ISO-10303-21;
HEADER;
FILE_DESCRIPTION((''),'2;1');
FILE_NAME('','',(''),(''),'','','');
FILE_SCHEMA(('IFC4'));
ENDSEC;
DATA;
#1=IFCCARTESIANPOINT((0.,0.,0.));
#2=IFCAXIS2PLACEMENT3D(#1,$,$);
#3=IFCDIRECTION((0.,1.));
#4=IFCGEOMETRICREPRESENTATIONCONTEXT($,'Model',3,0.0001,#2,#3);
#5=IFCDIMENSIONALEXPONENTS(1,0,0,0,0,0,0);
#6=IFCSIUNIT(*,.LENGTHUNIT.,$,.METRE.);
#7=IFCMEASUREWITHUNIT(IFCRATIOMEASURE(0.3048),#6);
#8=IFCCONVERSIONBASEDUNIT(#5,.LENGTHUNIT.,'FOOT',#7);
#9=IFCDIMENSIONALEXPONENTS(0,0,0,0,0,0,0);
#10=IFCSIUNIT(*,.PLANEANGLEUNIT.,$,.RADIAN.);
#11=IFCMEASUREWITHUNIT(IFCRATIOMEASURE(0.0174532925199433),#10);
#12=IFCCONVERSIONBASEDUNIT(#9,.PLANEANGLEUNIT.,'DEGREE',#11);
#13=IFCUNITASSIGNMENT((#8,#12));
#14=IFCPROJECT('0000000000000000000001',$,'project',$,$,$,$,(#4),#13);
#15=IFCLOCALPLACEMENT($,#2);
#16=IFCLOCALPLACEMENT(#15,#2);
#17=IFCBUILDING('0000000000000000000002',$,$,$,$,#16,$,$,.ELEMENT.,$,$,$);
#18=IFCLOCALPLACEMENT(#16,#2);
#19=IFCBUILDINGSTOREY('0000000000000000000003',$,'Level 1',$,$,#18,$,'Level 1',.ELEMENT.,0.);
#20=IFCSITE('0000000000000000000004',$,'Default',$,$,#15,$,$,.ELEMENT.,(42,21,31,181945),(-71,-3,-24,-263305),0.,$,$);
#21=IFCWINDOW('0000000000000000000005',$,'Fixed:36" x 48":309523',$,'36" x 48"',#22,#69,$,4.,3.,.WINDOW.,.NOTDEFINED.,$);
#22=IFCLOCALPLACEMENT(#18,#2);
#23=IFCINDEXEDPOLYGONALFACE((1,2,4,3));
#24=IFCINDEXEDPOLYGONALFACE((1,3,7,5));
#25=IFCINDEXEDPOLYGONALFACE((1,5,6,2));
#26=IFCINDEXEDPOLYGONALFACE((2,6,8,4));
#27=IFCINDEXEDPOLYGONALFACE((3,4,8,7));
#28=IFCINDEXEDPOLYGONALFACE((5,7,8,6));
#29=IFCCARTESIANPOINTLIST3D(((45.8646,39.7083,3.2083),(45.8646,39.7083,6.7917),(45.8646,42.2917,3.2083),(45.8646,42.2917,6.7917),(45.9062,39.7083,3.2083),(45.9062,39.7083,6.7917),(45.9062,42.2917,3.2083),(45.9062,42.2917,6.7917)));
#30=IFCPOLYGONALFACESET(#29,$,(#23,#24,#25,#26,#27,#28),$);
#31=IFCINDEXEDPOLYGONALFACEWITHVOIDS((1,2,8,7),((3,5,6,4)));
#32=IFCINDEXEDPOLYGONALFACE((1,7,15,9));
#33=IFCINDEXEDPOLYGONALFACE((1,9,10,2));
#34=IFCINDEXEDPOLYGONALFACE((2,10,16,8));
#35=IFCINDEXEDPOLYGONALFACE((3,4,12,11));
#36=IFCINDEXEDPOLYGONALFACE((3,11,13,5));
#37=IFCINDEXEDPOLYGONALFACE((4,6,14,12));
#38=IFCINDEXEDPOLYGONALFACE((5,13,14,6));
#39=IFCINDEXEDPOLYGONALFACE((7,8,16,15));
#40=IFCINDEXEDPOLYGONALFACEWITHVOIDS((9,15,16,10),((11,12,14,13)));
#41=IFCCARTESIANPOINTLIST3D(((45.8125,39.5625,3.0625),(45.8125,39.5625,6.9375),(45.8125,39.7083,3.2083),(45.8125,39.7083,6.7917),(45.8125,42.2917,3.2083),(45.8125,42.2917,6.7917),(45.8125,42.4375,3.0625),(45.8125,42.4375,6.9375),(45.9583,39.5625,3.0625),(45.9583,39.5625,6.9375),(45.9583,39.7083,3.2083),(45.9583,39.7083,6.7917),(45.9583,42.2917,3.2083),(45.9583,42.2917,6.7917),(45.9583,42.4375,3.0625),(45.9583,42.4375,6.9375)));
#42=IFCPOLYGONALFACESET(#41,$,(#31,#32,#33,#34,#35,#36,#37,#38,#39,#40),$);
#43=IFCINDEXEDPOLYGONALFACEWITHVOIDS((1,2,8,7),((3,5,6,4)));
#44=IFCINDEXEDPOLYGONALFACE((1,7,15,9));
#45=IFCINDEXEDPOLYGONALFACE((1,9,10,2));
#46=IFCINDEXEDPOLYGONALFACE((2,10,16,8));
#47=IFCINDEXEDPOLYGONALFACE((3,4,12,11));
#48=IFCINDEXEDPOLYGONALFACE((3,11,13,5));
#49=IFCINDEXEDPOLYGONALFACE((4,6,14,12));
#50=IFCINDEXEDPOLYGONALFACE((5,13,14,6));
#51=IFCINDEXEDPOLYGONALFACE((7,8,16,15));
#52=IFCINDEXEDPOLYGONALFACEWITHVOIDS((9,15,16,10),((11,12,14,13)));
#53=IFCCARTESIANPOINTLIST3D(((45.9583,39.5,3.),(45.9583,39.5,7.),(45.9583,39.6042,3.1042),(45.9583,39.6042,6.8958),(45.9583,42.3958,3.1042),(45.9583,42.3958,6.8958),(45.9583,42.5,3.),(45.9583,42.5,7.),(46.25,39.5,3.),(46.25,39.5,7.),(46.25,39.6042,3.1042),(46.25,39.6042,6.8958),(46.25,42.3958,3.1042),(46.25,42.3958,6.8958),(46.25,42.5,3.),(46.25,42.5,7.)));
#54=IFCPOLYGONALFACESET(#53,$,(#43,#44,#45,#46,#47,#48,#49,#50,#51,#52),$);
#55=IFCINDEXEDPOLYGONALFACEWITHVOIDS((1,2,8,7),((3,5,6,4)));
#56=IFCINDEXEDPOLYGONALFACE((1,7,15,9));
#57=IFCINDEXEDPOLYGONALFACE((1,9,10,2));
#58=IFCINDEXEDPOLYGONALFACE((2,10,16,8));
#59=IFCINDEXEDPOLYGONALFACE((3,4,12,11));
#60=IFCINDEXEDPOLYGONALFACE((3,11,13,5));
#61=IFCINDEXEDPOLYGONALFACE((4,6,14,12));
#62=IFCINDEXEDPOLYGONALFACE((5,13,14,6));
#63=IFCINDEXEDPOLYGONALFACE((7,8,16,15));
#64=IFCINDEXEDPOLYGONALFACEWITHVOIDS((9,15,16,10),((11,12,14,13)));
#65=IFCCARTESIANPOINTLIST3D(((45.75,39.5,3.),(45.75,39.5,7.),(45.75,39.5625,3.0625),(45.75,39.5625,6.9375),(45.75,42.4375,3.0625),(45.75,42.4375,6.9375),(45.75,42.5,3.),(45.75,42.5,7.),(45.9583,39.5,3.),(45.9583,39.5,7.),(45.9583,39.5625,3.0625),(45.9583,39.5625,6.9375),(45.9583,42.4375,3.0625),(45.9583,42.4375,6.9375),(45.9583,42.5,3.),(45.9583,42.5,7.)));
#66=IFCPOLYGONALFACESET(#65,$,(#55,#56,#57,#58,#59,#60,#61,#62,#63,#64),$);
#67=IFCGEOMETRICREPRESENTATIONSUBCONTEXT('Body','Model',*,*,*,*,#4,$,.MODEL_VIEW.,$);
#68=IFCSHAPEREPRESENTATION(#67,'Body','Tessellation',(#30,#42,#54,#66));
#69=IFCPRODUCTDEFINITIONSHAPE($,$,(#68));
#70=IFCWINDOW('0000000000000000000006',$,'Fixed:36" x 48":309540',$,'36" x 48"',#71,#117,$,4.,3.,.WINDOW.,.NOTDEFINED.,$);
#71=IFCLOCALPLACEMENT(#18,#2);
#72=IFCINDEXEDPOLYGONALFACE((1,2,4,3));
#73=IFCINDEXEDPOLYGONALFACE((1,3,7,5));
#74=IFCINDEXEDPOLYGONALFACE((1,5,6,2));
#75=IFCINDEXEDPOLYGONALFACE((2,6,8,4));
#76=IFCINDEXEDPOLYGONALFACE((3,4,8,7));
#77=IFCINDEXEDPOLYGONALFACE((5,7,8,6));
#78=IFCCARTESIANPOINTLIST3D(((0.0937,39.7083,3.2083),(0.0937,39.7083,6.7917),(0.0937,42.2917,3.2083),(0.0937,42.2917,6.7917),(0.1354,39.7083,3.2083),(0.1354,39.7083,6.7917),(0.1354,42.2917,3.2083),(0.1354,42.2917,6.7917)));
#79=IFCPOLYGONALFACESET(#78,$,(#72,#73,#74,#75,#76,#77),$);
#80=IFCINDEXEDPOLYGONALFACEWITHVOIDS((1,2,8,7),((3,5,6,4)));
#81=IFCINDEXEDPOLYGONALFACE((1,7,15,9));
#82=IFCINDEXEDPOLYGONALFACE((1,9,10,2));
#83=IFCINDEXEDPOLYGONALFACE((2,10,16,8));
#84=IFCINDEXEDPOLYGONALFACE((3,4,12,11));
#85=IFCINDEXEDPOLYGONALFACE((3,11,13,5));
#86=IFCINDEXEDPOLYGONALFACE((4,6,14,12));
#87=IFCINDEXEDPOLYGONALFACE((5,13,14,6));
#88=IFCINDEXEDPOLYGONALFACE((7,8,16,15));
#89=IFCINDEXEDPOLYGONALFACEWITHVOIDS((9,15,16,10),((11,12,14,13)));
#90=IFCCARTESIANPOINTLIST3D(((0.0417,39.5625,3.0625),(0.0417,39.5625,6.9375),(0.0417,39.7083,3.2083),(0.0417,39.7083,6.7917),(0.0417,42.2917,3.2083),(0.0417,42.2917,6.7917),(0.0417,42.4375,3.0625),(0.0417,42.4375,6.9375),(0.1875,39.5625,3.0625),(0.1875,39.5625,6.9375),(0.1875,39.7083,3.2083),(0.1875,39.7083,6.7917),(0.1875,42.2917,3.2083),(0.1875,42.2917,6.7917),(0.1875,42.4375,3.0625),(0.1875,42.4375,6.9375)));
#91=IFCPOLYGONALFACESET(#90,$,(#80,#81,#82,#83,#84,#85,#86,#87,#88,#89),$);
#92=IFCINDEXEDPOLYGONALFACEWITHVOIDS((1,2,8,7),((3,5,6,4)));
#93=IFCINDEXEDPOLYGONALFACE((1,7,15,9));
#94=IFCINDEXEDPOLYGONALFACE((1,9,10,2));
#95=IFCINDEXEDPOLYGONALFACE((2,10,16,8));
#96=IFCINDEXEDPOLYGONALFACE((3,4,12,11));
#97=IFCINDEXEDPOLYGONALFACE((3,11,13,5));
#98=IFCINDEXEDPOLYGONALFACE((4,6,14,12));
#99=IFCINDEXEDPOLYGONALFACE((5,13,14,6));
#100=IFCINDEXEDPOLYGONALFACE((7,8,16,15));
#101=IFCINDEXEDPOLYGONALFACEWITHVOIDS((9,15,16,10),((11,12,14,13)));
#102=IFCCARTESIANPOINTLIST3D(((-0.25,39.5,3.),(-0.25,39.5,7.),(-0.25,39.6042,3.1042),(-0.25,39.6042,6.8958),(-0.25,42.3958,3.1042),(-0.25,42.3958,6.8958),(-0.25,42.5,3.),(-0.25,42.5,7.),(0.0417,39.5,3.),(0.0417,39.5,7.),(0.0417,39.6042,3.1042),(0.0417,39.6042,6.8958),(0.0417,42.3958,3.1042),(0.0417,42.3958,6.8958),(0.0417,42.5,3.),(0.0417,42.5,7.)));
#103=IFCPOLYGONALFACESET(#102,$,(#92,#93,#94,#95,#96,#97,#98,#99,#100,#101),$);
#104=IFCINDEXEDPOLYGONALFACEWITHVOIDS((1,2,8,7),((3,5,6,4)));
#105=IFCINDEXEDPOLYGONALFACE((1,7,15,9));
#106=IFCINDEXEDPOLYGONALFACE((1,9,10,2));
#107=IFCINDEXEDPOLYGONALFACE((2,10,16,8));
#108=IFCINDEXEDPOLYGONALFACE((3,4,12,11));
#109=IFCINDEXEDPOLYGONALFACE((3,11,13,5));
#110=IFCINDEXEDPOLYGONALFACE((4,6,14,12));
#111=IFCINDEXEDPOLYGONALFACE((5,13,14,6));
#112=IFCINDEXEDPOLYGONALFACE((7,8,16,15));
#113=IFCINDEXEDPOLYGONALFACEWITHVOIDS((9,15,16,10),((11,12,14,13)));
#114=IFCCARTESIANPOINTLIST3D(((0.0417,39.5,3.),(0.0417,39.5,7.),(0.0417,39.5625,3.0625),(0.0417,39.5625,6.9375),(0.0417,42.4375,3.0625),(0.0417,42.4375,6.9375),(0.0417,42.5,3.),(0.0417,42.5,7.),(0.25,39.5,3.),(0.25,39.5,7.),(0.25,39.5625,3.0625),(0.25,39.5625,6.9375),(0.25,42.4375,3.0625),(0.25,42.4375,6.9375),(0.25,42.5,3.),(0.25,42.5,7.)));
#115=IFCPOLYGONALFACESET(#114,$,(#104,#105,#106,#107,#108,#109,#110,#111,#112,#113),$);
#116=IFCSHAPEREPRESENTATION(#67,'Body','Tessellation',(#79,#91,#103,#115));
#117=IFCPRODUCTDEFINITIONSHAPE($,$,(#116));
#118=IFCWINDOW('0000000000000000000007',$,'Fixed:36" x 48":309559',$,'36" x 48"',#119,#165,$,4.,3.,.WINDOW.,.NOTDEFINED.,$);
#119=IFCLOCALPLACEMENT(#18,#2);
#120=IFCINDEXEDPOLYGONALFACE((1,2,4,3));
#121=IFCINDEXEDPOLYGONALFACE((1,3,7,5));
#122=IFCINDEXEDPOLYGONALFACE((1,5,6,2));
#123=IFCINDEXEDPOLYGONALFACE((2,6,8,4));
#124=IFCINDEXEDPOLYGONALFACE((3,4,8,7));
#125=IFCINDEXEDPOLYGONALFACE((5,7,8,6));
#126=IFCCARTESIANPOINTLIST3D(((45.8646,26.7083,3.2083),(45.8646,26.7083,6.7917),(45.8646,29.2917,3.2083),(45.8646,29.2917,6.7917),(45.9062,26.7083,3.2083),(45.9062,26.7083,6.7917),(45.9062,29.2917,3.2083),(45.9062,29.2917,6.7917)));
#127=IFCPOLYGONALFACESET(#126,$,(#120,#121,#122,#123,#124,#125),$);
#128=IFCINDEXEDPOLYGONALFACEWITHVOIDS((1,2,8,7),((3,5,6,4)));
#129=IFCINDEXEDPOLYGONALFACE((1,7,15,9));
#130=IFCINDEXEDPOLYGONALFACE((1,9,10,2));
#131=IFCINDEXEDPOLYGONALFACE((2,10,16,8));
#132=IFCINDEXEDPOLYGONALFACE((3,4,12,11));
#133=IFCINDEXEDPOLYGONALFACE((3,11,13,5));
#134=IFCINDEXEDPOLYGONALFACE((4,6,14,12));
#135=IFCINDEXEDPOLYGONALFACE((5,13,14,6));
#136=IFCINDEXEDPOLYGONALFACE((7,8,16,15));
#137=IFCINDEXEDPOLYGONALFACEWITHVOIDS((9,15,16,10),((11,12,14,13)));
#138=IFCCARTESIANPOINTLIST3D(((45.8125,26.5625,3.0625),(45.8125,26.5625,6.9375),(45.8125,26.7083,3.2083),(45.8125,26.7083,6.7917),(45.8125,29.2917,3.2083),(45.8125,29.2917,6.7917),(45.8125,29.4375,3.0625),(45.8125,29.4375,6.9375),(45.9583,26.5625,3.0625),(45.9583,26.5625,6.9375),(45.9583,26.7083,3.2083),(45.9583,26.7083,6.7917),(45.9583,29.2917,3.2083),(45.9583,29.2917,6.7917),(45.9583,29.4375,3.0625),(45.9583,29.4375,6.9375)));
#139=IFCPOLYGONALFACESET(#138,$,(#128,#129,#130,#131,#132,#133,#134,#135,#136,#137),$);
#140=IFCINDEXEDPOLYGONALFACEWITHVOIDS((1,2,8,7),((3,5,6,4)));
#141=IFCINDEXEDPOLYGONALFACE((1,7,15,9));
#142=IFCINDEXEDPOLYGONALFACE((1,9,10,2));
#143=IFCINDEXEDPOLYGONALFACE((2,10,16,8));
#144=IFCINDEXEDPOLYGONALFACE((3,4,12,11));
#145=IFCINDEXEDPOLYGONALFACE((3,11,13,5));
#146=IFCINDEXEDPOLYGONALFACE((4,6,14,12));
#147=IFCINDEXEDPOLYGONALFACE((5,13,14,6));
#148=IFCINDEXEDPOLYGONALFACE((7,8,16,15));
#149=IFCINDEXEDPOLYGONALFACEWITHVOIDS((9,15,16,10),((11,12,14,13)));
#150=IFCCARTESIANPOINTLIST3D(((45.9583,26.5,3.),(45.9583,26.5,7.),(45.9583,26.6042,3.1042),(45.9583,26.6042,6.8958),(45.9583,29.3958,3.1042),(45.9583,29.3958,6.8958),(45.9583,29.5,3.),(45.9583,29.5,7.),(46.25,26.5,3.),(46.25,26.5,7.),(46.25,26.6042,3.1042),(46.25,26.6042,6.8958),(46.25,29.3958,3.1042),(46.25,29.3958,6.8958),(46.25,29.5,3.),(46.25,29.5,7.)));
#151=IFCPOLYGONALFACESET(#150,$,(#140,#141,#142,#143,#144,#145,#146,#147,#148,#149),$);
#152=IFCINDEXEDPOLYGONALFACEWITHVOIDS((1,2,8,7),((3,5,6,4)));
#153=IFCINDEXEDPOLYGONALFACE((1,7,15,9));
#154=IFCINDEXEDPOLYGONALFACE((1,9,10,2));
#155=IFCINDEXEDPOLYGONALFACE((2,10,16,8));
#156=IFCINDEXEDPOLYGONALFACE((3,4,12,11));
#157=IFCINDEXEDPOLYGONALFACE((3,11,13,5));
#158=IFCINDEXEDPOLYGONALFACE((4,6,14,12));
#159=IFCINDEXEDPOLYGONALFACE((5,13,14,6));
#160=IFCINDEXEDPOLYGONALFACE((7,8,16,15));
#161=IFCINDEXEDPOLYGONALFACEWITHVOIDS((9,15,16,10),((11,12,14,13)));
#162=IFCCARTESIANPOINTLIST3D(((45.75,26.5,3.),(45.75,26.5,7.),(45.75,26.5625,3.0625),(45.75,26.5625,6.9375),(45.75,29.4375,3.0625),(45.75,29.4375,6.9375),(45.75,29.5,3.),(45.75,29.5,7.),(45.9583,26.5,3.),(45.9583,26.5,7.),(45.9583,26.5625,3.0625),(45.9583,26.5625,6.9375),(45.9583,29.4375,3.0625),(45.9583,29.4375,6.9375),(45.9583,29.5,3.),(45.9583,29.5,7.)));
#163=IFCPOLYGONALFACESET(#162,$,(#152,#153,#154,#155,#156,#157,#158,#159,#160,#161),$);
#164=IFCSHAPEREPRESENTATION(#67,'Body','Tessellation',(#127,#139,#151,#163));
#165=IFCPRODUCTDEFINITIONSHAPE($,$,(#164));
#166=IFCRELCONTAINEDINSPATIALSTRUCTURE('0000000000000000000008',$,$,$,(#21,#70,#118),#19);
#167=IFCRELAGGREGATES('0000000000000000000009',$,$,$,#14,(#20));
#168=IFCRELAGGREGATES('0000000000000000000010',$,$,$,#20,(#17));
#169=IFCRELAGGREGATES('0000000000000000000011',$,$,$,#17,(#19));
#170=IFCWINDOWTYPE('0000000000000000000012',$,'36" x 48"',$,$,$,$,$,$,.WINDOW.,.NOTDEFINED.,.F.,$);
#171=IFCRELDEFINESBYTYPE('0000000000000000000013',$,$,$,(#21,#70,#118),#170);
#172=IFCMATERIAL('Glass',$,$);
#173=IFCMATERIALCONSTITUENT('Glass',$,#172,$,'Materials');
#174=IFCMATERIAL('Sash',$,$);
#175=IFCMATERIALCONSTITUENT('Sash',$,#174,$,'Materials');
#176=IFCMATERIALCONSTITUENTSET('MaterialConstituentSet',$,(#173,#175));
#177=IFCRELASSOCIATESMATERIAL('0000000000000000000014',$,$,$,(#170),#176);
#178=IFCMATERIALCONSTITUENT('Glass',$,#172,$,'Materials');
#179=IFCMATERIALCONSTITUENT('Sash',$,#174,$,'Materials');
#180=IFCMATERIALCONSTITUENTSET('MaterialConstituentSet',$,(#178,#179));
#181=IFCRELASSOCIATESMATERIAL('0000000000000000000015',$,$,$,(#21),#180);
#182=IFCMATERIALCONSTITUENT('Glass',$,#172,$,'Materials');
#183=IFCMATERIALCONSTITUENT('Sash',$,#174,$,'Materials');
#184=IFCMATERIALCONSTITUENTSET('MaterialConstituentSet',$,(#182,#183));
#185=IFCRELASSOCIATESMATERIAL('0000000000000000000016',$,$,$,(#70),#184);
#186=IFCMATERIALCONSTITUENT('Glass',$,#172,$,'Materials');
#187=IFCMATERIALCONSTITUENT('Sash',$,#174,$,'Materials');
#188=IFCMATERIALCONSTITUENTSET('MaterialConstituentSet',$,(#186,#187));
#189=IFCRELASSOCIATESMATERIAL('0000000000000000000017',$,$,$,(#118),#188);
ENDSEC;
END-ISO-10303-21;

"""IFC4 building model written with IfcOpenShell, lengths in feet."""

from ifc_helpers import new_model, entity, si_unit, converted_unit, direction, frame, frame_2d, origin, place, context, subcontext, project, spatial, polyline, rectangle, outline, extrude, source, transform, mapped, material, constituent, constituent_set, type_object, type_shapes, element, save


model = new_model("IFC4")

# Units and contexts
model_context = context("Model", 3, precision=0.0001, world=origin(), true_north=direction((0.0, 1.0)))
body_context = subcontext(model_context, "Body", "Model", "MODEL_VIEW")
ifc_project = project(units=[converted_unit("LENGTHUNIT", "FOOT", entity("IfcRatioMeasure", 0.3048), si_unit("LENGTHUNIT", "METRE"), dimensions=[1, 0, 0, 0, 0, 0, 0]), converted_unit("PLANEANGLEUNIT", "DEGREE", entity("IfcRatioMeasure", 0.0174532925199433), si_unit("PLANEANGLEUNIT", "RADIAN"), dimensions=[0, 0, 0, 0, 0, 0, 0])], contexts=[model_context])

# Site, building, storey
site_placement = place(None, origin())
site = spatial("IfcSite", under=ifc_project, at=site_placement, Name="Default", CompositionType="ELEMENT", RefLatitude=(42, 21, 31, 181945), RefLongitude=(-71, -3, -24, -263305), RefElevation=0.0)
building_placement = place(site_placement, origin())
building = spatial("IfcBuilding", under=site, at=building_placement, CompositionType="ELEMENT")
storey_placement = place(building_placement, origin())
storey = spatial("IfcBuildingStorey", under=building, at=storey_placement, Name="Level 1", LongName="Level 1", CompositionType="ELEMENT", Elevation=0.0)

# Shared definitions
placement_1 = place(storey_placement, frame((46.0, 46.25, 0.0), z_axis=(0.0, 0.0, 1.0), x_axis=(0.0, -1.0, 0.0)))

# Windows
ifc_material_1 = material(Name="Glass")
ifc_material_2 = material(Name="Sash")
ifc_constituent_1 = constituent(ifc_material_1, Name="Glass", Category="Materials")
ifc_constituent_2 = constituent(ifc_material_2, Name="Sash", Category="Materials")
ifc_constituent_set_1 = constituent_set(constituents=[ifc_constituent_1, ifc_constituent_2], Name="MaterialConstituentSet")
window_type = type_object("IfcWindowType", Name="36\" x 48\"", ParameterTakesPrecedence=False, PartitioningType="NOTDEFINED", PredefinedType="WINDOW", material=ifc_constituent_set_1)
shared_shape_1 = source(origin(), body_context, "Body", "SweptSolid", [
    extrude(rectangle(XDim=0.0417, YDim=2.5833, at=frame_2d((0.0, 0.0), x_axis=(1.0, 0.0))), frame((1.5, 0.3646, 0.2083), z_axis=(0.0, 0.0, 1.0), x_axis=(0.0, 1.0, 0.0)), (0.0, 0.0, 1.0), 3.5833),
    extrude(outline(polyline([(-1.4375, -1.9375), (1.4375, -1.9375), (1.4375, 1.9375), (-1.4375, 1.9375), (-1.4375, -1.9375)]), holes=[polyline([(-1.2917, -1.7917), (-1.2917, 1.7917), (1.2917, 1.7917), (1.2917, -1.7917), (-1.2917, -1.7917)])]), frame((1.5, 0.2917, 2.0), z_axis=(0.0, 1.0, 0.0), x_axis=(1.0, 0.0, 0.0)), (0.0, 0.0, 1.0), 0.1458),
    extrude(outline(polyline([(-1.5, -2.0), (1.5, -2.0), (1.5, 2.0), (-1.5, 2.0), (-1.5, -2.0)]), holes=[polyline([(-1.3958, -1.8958), (-1.3958, 1.8958), (1.3958, 1.8958), (1.3958, -1.8958), (-1.3958, -1.8958)])]), frame((1.5, 0.0, 2.0), z_axis=(0.0, 1.0, 0.0), x_axis=(1.0, 0.0, 0.0)), (0.0, 0.0, 1.0), 0.2917),
    extrude(outline(polyline([(-2.0, -1.5), (2.0, -1.5), (2.0, 1.5), (-2.0, 1.5), (-2.0, -1.5)]), holes=[polyline([(-1.9375, -1.4375), (-1.9375, 1.4375), (1.9375, 1.4375), (1.9375, -1.4375), (-1.9375, -1.4375)])]), frame((1.5, 0.2917, 2.0), z_axis=(0.0, 1.0, 0.0), x_axis=(0.0, 0.0, -1.0)), (0.0, 0.0, 1.0), 0.2083),
])
type_shapes(window_type, [shared_shape_1])
ifc_constituent_3 = constituent(ifc_material_1, Name="Glass", Category="Materials")
ifc_constituent_4 = constituent(ifc_material_2, Name="Sash", Category="Materials")
ifc_constituent_set_2 = constituent_set(constituents=[ifc_constituent_3, ifc_constituent_4], Name="MaterialConstituentSet")
placement_2 = place(placement_1, frame((6.75, 0.25, 3.0)))
window_1_placement = place(placement_2, frame((0.0, 0.0, 0.0), z_axis=(0.0, 0.0, 1.0), x_axis=(-1.0, 0.0, 0.0)))
element("IfcWindow", 1, at=window_1_placement, inside=storey, type_object=window_type, material=ifc_constituent_set_2, Name="Fixed:36\" x 48\":309523", ObjectType="36\" x 48\"", OverallHeight=4.0, OverallWidth=3.0, PartitioningType="NOTDEFINED", PredefinedType="WINDOW", context=body_context, shape_type="MappedRepresentation", body=[
    mapped(shared_shape_1, transform((0.0, 0.0, 0.0), scale=1.0)),
])
ifc_constituent_5 = constituent(ifc_material_1, Name="Glass", Category="Materials")
ifc_constituent_6 = constituent(ifc_material_2, Name="Sash", Category="Materials")
ifc_constituent_set_3 = constituent_set(constituents=[ifc_constituent_5, ifc_constituent_6], Name="MaterialConstituentSet")
placement_3 = place(storey_placement, frame((0.0, -0.25, 0.0), z_axis=(0.0, 0.0, 1.0), x_axis=(0.0, 1.0, 0.0)))
placement_4 = place(placement_3, frame((42.75, 0.25, 3.0)))
window_2_placement = place(placement_4, frame((0.0, 0.0, 0.0), z_axis=(0.0, 0.0, 1.0), x_axis=(-1.0, 0.0, 0.0)))
element("IfcWindow", 2, at=window_2_placement, inside=storey, type_object=window_type, material=ifc_constituent_set_3, Name="Fixed:36\" x 48\":309540", ObjectType="36\" x 48\"", OverallHeight=4.0, OverallWidth=3.0, PartitioningType="NOTDEFINED", PredefinedType="WINDOW", context=body_context, shape_type="MappedRepresentation", body=[
    mapped(shared_shape_1, transform((0.0, 0.0, 0.0), scale=1.0)),
])
ifc_constituent_7 = constituent(ifc_material_1, Name="Glass", Category="Materials")
ifc_constituent_8 = constituent(ifc_material_2, Name="Sash", Category="Materials")
ifc_constituent_set_4 = constituent_set(constituents=[ifc_constituent_7, ifc_constituent_8], Name="MaterialConstituentSet")
placement_5 = place(placement_1, frame((19.75, 0.25, 3.0)))
window_3_placement = place(placement_5, frame((0.0, 0.0, 0.0), z_axis=(0.0, 0.0, 1.0), x_axis=(-1.0, 0.0, 0.0)))
element("IfcWindow", 3, at=window_3_placement, inside=storey, type_object=window_type, material=ifc_constituent_set_4, Name="Fixed:36\" x 48\":309559", ObjectType="36\" x 48\"", OverallHeight=4.0, OverallWidth=3.0, PartitioningType="NOTDEFINED", PredefinedType="WINDOW", context=body_context, shape_type="MappedRepresentation", body=[
    mapped(shared_shape_1, transform((0.0, 0.0, 0.0), scale=1.0)),
])

save(model, "model.ifc")
